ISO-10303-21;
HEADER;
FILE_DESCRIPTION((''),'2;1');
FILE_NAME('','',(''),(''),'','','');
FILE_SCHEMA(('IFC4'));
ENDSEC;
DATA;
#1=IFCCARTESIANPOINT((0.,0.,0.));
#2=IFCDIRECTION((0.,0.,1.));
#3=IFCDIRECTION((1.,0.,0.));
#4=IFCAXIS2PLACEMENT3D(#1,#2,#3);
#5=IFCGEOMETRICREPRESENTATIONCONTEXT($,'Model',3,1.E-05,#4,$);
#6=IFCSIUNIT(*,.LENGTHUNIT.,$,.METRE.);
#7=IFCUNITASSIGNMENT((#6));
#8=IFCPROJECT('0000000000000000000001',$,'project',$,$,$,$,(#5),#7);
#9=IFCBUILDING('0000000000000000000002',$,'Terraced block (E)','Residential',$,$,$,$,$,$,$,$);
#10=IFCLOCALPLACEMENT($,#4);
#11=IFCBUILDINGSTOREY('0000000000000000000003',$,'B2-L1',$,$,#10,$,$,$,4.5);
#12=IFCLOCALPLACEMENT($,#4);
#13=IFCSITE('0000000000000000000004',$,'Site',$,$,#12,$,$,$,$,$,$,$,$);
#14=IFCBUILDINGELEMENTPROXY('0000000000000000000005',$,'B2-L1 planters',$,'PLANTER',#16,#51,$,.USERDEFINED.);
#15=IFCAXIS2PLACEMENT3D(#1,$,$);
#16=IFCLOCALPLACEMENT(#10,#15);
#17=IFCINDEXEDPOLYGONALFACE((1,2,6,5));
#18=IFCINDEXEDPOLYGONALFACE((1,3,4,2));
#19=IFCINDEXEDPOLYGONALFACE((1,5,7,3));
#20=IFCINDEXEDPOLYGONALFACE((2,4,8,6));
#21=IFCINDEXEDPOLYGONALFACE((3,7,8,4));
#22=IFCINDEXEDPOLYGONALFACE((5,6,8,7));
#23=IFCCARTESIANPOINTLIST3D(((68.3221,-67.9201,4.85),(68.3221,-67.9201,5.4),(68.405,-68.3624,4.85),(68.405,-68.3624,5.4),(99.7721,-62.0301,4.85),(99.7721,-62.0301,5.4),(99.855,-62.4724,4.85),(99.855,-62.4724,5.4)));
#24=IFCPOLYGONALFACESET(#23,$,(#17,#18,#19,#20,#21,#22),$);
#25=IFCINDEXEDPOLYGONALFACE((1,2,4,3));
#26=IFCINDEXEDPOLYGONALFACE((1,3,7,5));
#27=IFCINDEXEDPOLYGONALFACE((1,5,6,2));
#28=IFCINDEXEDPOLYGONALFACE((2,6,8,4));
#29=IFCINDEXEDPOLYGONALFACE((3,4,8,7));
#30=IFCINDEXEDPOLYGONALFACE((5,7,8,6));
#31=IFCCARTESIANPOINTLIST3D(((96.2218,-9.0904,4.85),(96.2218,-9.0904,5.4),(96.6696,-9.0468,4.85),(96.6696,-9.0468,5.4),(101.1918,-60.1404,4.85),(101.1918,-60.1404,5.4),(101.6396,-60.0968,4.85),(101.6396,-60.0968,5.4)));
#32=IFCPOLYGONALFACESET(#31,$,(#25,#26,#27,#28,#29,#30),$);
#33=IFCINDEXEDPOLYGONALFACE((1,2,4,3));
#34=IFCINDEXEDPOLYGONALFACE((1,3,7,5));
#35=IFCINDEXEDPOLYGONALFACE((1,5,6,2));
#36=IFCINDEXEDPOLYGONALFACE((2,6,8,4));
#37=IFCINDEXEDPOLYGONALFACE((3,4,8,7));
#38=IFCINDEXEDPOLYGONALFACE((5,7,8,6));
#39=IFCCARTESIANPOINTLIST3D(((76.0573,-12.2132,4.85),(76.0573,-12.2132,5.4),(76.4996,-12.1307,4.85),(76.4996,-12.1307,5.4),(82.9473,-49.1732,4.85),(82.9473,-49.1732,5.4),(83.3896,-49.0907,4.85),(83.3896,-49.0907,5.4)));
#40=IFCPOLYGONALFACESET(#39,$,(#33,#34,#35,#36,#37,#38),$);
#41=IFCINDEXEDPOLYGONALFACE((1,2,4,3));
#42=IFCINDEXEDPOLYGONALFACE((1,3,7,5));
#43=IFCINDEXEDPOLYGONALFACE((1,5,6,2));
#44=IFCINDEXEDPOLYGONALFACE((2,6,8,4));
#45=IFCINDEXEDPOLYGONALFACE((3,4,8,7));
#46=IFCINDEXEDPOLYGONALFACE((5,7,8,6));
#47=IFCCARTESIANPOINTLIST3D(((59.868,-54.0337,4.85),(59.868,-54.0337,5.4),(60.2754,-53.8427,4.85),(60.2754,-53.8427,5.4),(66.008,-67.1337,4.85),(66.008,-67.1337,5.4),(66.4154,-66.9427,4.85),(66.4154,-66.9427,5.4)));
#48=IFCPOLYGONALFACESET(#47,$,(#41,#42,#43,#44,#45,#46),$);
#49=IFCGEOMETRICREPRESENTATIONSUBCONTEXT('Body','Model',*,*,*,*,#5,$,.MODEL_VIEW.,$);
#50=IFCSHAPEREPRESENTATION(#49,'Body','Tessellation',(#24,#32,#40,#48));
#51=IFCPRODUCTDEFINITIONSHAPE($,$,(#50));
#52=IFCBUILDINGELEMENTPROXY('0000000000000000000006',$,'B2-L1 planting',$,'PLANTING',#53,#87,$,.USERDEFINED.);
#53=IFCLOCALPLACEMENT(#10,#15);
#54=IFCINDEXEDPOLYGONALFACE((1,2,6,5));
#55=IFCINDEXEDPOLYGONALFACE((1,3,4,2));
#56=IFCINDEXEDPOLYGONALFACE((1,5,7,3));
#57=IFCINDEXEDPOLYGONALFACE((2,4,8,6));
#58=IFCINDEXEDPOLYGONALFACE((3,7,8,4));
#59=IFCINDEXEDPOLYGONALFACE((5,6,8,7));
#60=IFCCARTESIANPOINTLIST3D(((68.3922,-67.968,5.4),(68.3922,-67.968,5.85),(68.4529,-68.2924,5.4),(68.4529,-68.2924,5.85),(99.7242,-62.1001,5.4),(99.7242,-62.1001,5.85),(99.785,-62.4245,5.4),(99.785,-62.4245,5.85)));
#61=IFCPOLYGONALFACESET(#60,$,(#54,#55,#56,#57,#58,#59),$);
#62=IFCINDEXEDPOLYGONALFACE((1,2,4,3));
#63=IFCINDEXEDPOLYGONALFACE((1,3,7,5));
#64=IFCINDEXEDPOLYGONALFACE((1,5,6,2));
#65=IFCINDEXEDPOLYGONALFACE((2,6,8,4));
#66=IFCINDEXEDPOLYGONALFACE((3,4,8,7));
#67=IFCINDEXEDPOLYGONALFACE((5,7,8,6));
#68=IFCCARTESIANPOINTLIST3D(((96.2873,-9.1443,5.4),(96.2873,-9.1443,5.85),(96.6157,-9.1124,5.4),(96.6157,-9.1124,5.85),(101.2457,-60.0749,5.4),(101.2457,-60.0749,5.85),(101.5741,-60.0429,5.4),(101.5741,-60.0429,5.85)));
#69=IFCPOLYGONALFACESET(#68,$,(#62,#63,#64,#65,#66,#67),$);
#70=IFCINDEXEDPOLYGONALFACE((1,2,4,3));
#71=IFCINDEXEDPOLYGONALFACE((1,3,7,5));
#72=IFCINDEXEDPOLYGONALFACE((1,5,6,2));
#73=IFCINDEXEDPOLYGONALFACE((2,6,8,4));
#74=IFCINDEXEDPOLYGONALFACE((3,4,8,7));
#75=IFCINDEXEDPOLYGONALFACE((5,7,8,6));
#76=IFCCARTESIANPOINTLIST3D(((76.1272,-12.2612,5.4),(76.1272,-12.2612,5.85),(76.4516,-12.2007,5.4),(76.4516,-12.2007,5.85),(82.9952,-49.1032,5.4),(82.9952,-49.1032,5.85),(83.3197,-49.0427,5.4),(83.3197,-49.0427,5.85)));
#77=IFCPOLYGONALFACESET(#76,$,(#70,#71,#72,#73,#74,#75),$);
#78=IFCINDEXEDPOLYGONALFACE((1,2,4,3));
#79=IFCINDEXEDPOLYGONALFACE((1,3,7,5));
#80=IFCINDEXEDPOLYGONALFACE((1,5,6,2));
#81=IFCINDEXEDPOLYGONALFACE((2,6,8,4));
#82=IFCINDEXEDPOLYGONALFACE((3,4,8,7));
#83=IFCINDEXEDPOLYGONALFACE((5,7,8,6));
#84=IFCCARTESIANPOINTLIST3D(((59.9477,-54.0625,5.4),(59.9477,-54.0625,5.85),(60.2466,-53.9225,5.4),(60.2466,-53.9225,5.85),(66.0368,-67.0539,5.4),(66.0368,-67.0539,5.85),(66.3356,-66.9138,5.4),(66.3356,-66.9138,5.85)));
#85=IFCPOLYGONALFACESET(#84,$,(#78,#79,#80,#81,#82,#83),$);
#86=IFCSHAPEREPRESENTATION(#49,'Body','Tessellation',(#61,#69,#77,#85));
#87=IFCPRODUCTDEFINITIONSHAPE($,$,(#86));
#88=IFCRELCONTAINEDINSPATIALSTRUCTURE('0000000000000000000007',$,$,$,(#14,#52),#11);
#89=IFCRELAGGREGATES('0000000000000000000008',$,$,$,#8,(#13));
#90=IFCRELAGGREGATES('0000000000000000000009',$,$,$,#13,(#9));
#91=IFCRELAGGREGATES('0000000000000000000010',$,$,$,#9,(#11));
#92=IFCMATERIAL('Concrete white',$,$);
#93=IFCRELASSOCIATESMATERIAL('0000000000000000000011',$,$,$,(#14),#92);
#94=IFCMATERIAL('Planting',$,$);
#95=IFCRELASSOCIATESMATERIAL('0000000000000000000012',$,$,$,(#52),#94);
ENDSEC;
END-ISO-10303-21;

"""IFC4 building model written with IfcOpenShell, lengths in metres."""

from ifc_helpers import new_model, si_unit, frame, origin_with_axes, place, context, subcontext, project, spatial, polyline, outline, extrude, material, element, save


model = new_model("IFC4")

# Units and contexts
model_context = context("Model", 3, precision=1e-05, world=origin_with_axes())
body_context = subcontext(model_context, "Body", "Model", "MODEL_VIEW")
ifc_project = project(units=[si_unit("LENGTHUNIT", "METRE")], contexts=[model_context])

# Site, building, storey
site_placement = place(None, origin_with_axes())
site = spatial("IfcSite", under=ifc_project, at=site_placement, Name="Site")
building = spatial("IfcBuilding", under=site, Name="Terraced block (E)", Description="Residential")
storey_placement = place(None, origin_with_axes())
storey = spatial("IfcBuildingStorey", under=building, at=storey_placement, Name="B2-L1", Elevation=4.5)

# Shared definitions
ifc_material_1 = material(Name="Concrete white")

# Building element proxies
proxy_1_placement = place(storey_placement, origin_with_axes())
element("IfcBuildingElementProxy", 1, at=proxy_1_placement, inside=storey, material=ifc_material_1, Name="B2-L1 planters", ObjectType="PLANTER", PredefinedType="USERDEFINED", context=body_context, shape_type="SweptSolid", body=[
    extrude(outline(polyline([(68.405, -68.3624), (99.855, -62.4724), (99.7721, -62.0301), (68.3221, -67.9201), (68.405, -68.3624)])), frame((0.0, 0.0, 4.85), z_axis=(0.0, 0.0, 1.0), x_axis=(1.0, 0.0, 0.0)), (0.0, 0.0, 1.0), 0.55),
    extrude(outline(polyline([(101.6396, -60.0968), (96.6696, -9.0468), (96.2218, -9.0904), (101.1918, -60.1404), (101.6396, -60.0968)])), frame((0.0, 0.0, 4.85), z_axis=(0.0, 0.0, 1.0), x_axis=(1.0, 0.0, 0.0)), (0.0, 0.0, 1.0), 0.55),
    extrude(outline(polyline([(76.0573, -12.2132), (82.9473, -49.1732), (83.3896, -49.0907), (76.4996, -12.1307), (76.0573, -12.2132)])), frame((0.0, 0.0, 4.85), z_axis=(0.0, 0.0, 1.0), x_axis=(1.0, 0.0, 0.0)), (0.0, 0.0, 1.0), 0.55),
    extrude(outline(polyline([(59.868, -54.0337), (66.008, -67.1337), (66.4154, -66.9427), (60.2754, -53.8427), (59.868, -54.0337)])), frame((0.0, 0.0, 4.85), z_axis=(0.0, 0.0, 1.0), x_axis=(1.0, 0.0, 0.0)), (0.0, 0.0, 1.0), 0.55),
])
ifc_material_2 = material(Name="Planting")
proxy_2_placement = place(storey_placement, origin_with_axes())
element("IfcBuildingElementProxy", 2, at=proxy_2_placement, inside=storey, material=ifc_material_2, Name="B2-L1 planting", ObjectType="PLANTING", PredefinedType="USERDEFINED", context=body_context, shape_type="SweptSolid", body=[
    extrude(outline(polyline([(68.4529, -68.2924), (99.785, -62.4245), (99.7242, -62.1001), (68.3922, -67.968), (68.4529, -68.2924)])), frame((0.0, 0.0, 5.4), z_axis=(0.0, 0.0, 1.0), x_axis=(1.0, 0.0, 0.0)), (0.0, 0.0, 1.0), 0.45),
    extrude(outline(polyline([(101.5741, -60.0429), (96.6157, -9.1124), (96.2873, -9.1443), (101.2457, -60.0749), (101.5741, -60.0429)])), frame((0.0, 0.0, 5.4), z_axis=(0.0, 0.0, 1.0), x_axis=(1.0, 0.0, 0.0)), (0.0, 0.0, 1.0), 0.45),
    extrude(outline(polyline([(76.1272, -12.2612), (82.9952, -49.1032), (83.3197, -49.0427), (76.4516, -12.2007), (76.1272, -12.2612)])), frame((0.0, 0.0, 5.4), z_axis=(0.0, 0.0, 1.0), x_axis=(1.0, 0.0, 0.0)), (0.0, 0.0, 1.0), 0.45),
    extrude(outline(polyline([(59.9477, -54.0625), (66.0368, -67.0539), (66.3356, -66.9138), (60.2466, -53.9225), (59.9477, -54.0625)])), frame((0.0, 0.0, 5.4), z_axis=(0.0, 0.0, 1.0), x_axis=(1.0, 0.0, 0.0)), (0.0, 0.0, 1.0), 0.45),
])

save(model, "model.ifc")
